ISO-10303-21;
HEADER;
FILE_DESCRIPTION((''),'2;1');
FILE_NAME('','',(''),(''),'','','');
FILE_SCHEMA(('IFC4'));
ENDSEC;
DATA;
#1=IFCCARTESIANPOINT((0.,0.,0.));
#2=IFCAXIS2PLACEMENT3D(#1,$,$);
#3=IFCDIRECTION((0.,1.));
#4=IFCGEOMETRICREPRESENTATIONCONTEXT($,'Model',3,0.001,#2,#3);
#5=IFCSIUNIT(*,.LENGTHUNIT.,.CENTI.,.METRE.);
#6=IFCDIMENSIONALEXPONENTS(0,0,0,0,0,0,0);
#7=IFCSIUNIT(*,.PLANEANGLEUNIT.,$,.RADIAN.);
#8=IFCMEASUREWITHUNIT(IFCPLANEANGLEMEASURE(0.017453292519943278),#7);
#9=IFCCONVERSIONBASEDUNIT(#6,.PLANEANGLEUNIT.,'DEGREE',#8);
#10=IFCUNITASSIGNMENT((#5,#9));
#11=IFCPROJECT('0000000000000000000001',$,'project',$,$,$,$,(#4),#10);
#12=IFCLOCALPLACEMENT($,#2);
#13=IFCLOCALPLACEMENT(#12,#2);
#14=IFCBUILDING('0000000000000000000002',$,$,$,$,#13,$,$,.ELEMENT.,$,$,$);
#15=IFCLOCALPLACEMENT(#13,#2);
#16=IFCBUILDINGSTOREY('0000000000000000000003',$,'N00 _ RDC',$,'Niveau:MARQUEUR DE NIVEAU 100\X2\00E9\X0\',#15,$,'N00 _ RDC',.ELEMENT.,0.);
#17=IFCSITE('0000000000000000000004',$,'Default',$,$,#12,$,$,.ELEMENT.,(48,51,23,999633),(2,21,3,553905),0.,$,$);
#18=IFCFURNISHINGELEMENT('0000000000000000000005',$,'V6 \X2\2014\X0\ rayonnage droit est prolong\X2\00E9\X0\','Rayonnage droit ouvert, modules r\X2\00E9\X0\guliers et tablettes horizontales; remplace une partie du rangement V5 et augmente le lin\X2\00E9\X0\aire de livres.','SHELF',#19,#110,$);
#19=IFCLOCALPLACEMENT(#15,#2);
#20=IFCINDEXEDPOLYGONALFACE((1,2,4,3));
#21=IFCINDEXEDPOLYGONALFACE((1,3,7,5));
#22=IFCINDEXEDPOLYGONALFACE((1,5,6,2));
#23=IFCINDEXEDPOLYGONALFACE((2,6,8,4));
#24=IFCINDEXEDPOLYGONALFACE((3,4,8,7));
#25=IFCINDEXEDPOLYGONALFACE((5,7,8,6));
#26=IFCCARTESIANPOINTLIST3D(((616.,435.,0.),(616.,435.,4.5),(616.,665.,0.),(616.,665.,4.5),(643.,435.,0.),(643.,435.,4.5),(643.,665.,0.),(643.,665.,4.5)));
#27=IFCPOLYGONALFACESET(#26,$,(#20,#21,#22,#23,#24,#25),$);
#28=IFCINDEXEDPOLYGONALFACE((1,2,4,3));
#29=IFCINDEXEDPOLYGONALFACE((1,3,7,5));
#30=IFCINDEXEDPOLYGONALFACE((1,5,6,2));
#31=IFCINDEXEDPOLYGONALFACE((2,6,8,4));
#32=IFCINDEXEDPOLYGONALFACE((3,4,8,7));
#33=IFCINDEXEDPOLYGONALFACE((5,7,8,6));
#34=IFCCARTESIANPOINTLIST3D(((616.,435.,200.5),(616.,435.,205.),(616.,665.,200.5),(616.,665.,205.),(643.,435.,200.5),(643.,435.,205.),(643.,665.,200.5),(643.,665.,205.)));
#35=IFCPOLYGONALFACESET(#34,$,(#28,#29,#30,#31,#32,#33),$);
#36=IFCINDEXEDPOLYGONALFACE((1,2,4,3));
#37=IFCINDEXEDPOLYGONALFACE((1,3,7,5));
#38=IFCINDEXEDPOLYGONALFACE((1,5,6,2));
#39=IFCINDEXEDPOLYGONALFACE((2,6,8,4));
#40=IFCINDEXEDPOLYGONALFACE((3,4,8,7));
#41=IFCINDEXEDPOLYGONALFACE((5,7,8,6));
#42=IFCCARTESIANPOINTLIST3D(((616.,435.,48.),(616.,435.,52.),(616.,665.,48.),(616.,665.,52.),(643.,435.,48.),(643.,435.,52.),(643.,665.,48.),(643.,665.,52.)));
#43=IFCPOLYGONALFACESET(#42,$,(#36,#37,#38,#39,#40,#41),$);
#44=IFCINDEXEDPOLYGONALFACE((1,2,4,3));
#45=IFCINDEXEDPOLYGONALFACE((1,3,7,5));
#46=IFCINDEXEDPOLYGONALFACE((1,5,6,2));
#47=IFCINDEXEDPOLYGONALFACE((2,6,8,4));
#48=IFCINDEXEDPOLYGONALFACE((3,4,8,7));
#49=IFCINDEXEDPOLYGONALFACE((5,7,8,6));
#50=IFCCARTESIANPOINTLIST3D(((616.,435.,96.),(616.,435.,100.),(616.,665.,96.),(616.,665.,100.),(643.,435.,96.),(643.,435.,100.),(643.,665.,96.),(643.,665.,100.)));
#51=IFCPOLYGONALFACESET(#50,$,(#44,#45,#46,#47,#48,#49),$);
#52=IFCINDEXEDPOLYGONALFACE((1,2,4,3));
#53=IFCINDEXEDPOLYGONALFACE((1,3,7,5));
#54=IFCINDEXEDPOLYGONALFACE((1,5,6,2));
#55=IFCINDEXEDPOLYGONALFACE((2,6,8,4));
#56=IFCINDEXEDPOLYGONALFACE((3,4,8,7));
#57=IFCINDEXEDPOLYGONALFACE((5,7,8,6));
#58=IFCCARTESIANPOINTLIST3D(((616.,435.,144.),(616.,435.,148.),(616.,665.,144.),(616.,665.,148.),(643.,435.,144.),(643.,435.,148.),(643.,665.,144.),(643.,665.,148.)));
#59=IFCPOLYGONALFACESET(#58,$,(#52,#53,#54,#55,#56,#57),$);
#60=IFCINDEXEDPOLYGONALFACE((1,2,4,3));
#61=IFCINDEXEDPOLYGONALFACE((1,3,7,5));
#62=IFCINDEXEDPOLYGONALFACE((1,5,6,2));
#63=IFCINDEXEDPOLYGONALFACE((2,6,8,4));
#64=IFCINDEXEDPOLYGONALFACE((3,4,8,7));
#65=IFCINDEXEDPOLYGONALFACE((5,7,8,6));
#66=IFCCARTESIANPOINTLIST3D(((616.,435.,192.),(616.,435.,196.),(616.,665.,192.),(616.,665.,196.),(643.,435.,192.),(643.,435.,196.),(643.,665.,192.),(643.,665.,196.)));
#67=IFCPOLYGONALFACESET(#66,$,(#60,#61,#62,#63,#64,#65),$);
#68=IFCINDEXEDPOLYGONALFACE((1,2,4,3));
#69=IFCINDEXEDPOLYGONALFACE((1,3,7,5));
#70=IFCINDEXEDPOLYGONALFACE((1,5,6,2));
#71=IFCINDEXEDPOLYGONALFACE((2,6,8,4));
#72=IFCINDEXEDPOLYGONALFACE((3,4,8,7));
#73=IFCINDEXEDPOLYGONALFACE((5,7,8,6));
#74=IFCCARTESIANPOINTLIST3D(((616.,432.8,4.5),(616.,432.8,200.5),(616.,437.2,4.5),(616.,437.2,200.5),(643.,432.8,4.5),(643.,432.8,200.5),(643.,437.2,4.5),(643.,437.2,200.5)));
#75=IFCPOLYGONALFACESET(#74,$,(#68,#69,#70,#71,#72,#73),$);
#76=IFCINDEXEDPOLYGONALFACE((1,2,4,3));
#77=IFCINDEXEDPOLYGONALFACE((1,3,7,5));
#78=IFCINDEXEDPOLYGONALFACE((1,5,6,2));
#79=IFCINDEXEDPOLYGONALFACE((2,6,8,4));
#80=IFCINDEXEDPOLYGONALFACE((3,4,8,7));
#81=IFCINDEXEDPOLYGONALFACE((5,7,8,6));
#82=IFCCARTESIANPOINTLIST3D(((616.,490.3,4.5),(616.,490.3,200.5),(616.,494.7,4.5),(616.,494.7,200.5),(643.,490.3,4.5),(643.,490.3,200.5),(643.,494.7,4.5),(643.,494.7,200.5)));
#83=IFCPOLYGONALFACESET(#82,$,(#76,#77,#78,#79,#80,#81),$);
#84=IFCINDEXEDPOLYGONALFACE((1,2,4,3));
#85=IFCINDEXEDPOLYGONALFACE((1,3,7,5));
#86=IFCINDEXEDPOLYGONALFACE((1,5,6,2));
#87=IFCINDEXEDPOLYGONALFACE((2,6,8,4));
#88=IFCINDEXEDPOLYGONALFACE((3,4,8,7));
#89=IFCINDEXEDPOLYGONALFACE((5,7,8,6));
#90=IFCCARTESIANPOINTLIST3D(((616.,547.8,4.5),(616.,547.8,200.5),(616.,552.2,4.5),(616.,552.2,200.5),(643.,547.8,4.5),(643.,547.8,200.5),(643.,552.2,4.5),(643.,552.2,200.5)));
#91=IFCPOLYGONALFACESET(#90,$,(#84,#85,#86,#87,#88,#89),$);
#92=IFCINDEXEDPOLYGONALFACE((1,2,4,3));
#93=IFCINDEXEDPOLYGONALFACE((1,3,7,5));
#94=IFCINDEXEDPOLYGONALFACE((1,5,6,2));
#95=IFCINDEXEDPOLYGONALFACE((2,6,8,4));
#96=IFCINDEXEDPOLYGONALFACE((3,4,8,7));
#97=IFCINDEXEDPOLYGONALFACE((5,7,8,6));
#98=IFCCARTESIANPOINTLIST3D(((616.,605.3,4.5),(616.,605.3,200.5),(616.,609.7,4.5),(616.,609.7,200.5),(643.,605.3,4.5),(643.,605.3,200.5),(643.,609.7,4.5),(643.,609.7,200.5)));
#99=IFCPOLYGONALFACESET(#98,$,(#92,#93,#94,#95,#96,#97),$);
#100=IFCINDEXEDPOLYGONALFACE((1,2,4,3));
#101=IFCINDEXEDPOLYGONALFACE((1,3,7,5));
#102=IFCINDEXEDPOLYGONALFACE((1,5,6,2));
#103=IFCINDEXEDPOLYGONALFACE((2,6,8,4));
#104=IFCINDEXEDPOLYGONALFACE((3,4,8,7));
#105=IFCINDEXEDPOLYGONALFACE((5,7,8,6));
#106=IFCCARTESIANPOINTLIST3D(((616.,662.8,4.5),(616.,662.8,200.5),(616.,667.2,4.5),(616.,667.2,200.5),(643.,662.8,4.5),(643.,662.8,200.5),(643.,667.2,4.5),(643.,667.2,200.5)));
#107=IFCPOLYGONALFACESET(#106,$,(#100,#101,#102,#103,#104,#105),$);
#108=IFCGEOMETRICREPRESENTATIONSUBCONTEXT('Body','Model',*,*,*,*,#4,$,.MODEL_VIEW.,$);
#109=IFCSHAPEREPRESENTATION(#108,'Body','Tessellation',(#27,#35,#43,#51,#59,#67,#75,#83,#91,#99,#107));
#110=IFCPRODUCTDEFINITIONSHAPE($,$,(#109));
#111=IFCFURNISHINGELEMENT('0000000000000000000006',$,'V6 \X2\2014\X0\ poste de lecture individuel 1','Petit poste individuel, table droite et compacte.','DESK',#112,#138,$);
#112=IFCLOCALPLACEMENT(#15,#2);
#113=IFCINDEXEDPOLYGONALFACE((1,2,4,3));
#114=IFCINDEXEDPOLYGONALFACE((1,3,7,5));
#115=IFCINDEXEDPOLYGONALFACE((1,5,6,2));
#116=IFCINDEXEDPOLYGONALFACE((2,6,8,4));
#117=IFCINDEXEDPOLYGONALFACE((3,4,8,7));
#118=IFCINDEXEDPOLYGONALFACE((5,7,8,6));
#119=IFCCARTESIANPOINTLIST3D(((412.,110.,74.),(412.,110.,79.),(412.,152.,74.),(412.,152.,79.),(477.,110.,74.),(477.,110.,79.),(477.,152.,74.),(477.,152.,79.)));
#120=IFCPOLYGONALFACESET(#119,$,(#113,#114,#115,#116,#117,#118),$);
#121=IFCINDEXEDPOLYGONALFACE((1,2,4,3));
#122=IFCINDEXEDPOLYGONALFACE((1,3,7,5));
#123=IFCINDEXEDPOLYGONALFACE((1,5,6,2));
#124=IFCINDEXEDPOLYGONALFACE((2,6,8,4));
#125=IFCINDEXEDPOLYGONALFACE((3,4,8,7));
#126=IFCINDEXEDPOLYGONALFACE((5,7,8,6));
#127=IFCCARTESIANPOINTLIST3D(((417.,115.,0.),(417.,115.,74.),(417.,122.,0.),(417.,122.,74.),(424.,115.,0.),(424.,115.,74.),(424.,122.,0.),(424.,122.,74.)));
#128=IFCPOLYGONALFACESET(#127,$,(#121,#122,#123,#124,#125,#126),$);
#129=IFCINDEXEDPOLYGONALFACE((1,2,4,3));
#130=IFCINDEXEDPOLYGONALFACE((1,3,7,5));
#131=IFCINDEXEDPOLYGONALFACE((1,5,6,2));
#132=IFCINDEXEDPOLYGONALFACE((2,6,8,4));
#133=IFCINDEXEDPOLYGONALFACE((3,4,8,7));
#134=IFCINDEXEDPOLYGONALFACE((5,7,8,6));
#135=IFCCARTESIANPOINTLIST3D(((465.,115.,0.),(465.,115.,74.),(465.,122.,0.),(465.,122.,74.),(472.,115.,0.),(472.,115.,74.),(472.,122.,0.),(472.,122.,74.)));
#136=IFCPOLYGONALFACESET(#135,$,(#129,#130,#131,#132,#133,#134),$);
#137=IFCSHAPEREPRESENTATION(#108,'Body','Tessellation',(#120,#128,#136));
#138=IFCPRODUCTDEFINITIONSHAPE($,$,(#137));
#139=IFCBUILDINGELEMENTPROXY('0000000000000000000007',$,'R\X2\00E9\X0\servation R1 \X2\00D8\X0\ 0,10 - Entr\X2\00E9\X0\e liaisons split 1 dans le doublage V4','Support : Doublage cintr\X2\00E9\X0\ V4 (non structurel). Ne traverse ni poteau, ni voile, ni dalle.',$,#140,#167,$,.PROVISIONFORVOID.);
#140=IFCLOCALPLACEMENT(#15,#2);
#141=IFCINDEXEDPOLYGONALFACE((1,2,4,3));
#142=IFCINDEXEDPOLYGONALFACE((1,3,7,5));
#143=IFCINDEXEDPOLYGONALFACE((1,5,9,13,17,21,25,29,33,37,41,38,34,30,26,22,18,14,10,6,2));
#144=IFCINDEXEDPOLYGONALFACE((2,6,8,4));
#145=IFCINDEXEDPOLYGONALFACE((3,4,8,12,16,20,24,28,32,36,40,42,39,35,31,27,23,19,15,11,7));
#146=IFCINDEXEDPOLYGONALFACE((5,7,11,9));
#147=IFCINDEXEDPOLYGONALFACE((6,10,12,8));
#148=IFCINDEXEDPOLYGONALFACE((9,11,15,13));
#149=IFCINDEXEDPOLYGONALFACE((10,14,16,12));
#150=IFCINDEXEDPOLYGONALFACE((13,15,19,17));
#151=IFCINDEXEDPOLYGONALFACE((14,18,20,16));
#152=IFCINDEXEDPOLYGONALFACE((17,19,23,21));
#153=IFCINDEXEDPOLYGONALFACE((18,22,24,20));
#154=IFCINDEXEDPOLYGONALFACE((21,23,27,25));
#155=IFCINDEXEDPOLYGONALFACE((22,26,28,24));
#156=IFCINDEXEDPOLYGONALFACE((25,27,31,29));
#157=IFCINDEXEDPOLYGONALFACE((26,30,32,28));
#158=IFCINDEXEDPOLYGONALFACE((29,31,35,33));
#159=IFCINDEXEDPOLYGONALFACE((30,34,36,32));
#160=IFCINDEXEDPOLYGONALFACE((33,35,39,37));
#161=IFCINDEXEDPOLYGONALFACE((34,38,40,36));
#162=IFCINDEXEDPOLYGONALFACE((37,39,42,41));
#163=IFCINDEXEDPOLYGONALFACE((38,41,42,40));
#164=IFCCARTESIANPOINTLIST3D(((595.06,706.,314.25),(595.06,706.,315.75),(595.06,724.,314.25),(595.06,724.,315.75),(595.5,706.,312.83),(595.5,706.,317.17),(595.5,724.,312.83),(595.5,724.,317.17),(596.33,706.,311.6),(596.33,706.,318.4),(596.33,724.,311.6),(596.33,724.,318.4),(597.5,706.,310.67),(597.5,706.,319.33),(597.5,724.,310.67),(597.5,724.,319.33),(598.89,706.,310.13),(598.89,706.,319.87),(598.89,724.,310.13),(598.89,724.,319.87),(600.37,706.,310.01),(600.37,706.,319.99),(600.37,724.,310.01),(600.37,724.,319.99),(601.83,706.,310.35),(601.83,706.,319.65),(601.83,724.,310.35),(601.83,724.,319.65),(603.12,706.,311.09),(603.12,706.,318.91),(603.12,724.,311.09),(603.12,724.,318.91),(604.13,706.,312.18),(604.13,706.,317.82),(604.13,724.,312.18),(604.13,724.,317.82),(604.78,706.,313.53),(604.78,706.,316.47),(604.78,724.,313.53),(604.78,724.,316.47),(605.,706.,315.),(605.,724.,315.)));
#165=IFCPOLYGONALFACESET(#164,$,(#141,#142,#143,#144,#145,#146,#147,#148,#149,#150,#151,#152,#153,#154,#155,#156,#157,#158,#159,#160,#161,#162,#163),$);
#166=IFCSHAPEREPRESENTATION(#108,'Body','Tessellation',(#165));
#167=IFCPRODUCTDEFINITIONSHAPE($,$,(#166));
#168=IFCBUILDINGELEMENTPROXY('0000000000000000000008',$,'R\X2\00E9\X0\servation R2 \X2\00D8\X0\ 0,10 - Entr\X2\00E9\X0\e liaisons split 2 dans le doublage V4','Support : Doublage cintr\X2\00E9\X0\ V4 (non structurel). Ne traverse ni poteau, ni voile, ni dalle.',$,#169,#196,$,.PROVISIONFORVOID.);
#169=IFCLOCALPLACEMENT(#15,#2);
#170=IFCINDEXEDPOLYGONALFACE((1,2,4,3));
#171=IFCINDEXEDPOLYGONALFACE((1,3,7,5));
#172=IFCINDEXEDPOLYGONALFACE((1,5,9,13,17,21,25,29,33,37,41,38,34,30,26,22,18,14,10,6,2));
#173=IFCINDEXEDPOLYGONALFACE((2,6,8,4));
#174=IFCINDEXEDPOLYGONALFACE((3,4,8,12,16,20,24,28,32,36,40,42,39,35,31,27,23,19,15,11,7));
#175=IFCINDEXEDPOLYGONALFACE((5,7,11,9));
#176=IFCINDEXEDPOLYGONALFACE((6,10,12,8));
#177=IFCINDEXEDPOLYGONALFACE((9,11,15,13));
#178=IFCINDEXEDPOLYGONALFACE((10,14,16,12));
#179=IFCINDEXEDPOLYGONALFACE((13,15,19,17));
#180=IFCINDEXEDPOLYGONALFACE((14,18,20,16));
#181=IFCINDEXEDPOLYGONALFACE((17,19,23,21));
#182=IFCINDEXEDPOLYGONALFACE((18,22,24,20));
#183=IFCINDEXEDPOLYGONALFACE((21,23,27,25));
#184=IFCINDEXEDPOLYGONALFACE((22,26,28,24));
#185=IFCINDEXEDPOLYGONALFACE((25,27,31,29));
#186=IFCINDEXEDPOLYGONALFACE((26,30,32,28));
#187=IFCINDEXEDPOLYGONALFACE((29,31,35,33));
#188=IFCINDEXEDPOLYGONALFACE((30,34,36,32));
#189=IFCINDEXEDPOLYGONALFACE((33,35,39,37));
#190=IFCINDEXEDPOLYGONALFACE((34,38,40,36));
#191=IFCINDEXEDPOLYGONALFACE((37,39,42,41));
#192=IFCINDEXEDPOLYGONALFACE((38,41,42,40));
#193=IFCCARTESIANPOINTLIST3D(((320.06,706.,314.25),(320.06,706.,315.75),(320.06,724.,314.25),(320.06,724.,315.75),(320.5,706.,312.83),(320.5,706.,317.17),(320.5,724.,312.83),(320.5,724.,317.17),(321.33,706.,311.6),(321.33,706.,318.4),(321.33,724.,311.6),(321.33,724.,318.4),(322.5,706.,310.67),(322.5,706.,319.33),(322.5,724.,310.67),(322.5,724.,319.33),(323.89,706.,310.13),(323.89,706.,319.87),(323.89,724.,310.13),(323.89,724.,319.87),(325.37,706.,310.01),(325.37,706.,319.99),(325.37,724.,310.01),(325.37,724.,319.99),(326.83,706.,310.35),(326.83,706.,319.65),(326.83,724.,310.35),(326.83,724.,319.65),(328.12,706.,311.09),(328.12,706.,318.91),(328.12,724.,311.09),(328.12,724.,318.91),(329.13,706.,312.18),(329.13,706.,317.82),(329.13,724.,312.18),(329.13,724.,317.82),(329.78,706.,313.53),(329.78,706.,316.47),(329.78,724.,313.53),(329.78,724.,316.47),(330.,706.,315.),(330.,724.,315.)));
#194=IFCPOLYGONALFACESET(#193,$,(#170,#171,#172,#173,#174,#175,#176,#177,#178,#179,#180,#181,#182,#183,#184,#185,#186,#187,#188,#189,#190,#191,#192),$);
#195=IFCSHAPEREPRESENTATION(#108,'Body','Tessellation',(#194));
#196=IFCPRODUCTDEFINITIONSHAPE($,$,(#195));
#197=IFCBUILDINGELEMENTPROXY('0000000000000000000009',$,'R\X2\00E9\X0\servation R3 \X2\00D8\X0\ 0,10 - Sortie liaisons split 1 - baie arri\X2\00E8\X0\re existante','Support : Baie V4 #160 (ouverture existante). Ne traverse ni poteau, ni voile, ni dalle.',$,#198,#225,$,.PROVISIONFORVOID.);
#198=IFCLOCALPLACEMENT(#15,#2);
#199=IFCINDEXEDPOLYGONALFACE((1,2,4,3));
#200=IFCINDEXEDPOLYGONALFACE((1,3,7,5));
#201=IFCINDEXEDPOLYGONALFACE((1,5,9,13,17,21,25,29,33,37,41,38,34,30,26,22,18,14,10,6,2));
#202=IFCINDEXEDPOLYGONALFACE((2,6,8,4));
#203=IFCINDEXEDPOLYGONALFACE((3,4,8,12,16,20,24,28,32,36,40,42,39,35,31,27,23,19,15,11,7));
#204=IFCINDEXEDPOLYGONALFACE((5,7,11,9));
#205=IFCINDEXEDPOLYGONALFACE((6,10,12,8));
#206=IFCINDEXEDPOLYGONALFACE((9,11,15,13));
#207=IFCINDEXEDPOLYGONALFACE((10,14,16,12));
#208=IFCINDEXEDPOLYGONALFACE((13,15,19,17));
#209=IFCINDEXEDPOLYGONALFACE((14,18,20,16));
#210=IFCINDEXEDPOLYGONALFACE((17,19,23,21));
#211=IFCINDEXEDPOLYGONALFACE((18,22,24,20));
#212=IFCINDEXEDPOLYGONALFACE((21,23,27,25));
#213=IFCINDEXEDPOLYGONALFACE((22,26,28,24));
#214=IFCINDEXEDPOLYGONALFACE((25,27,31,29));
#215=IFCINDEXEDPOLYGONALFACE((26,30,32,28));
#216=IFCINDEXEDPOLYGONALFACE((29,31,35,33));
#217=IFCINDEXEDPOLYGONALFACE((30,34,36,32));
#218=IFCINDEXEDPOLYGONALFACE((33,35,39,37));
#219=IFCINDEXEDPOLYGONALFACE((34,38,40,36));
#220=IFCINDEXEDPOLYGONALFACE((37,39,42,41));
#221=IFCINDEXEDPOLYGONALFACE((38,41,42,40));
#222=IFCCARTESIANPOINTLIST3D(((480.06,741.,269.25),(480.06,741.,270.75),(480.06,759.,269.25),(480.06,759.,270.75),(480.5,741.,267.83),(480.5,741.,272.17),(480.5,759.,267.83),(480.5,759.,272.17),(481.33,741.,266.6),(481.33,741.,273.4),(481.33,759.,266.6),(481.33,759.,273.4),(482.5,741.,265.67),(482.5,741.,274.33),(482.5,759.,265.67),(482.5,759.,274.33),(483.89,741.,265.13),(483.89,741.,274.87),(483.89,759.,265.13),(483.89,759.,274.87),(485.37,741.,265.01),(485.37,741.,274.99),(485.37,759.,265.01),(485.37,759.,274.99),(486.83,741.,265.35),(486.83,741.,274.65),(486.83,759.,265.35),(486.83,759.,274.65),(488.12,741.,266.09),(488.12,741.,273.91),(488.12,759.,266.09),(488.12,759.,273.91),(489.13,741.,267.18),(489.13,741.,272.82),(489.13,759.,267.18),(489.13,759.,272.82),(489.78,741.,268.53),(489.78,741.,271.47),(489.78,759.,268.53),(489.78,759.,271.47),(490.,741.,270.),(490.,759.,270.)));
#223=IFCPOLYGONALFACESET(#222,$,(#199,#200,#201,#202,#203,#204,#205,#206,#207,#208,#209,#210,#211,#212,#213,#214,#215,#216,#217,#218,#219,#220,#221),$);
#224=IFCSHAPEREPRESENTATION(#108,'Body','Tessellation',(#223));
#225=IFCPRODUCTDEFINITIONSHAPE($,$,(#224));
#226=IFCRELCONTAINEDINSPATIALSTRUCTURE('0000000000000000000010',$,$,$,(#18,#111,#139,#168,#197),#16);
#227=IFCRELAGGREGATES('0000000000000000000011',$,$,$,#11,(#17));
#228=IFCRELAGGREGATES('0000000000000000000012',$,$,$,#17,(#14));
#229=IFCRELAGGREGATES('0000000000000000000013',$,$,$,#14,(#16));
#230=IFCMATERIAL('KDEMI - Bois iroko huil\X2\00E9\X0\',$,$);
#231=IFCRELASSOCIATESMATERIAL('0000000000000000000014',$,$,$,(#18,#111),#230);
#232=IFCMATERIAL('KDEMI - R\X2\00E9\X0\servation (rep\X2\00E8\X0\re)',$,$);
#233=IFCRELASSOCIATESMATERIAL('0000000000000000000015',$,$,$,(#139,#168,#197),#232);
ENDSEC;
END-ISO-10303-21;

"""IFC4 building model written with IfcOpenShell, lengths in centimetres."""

from ifc_helpers import new_model, entity, si_unit, converted_unit, direction, frame, frame_2d, origin, origin_with_axes, origin_2d, place, context, subcontext, project, spatial, rectangle, circle, extrude, material, element, save


model = new_model("IFC4")

# Units and contexts
model_context = context("Model", 3, precision=0.001, world=origin(), true_north=direction((0.0, 1.0)))
body_context = subcontext(model_context, "Body", "Model", "MODEL_VIEW")
ifc_project = project(units=[si_unit("LENGTHUNIT", "METRE", prefix="CENTI"), converted_unit("PLANEANGLEUNIT", "DEGREE", entity("IfcPlaneAngleMeasure", 0.017453292519943278), si_unit("PLANEANGLEUNIT", "RADIAN"), dimensions=[0, 0, 0, 0, 0, 0, 0])], contexts=[model_context])

# Site, building, storey
site_placement = place(None, origin())
site = spatial("IfcSite", under=ifc_project, at=site_placement, Name="Default", CompositionType="ELEMENT", RefLatitude=(48, 51, 23, 999633), RefLongitude=(2, 21, 3, 553905), RefElevation=0.0)
building_placement = place(site_placement, origin())
building = spatial("IfcBuilding", under=site, at=building_placement, CompositionType="ELEMENT")
storey_placement = place(building_placement, origin())
storey = spatial("IfcBuildingStorey", under=building, at=storey_placement, Name="N00 _ RDC", ObjectType="Niveau:MARQUEUR DE NIVEAU 100é", LongName="N00 _ RDC", CompositionType="ELEMENT", Elevation=0.0)

# Furnishing elements
ifc_material_1 = material(Name="KDEMI - Bois iroko huilé")
furnishing_1_placement = place(storey_placement, origin_with_axes())
element("IfcFurnishingElement", 1, at=furnishing_1_placement, inside=storey, material=ifc_material_1, Name="V6 — rayonnage droit est prolongé", Description="Rayonnage droit ouvert, modules réguliers et tablettes horizontales; remplace une partie du rangement V5 et augmente le linéaire de livres.", ObjectType="SHELF", context=body_context, shape_type="SweptSolid", body=[
    extrude(rectangle(XDim=27.0, YDim=230.0, at=frame_2d((629.5, 550.0))), origin(), (0.0, 0.0, 1.0), 4.5),
    extrude(rectangle(XDim=27.0, YDim=230.0, at=frame_2d((629.5, 550.0))), frame((0.0, 0.0, 200.5)), (0.0, 0.0, 1.0), 4.5),
    extrude(rectangle(XDim=27.0, YDim=230.0, at=frame_2d((629.5, 550.0))), frame((0.0, 0.0, 48.0)), (0.0, 0.0, 1.0), 4.0),
    extrude(rectangle(XDim=27.0, YDim=230.0, at=frame_2d((629.5, 550.0))), frame((0.0, 0.0, 96.0)), (0.0, 0.0, 1.0), 4.0),
    extrude(rectangle(XDim=27.0, YDim=230.0, at=frame_2d((629.5, 550.0))), frame((0.0, 0.0, 144.0)), (0.0, 0.0, 1.0), 4.0),
    extrude(rectangle(XDim=27.0, YDim=230.0, at=frame_2d((629.5, 550.0))), frame((0.0, 0.0, 192.0)), (0.0, 0.0, 1.0), 4.0),
    extrude(rectangle(XDim=27.0, YDim=4.4, at=frame_2d((629.5, 435.0))), frame((0.0, 0.0, 4.5)), (0.0, 0.0, 1.0), 196.0),
    extrude(rectangle(XDim=27.0, YDim=4.4, at=frame_2d((629.5, 492.5))), frame((0.0, 0.0, 4.5)), (0.0, 0.0, 1.0), 196.0),
    extrude(rectangle(XDim=27.0, YDim=4.4, at=frame_2d((629.5, 550.0))), frame((0.0, 0.0, 4.5)), (0.0, 0.0, 1.0), 196.0),
    extrude(rectangle(XDim=27.0, YDim=4.4, at=frame_2d((629.5, 607.5))), frame((0.0, 0.0, 4.5)), (0.0, 0.0, 1.0), 196.0),
    extrude(rectangle(XDim=27.0, YDim=4.4, at=frame_2d((629.5, 665.0))), frame((0.0, 0.0, 4.5)), (0.0, 0.0, 1.0), 196.0),
])
furnishing_2_placement = place(storey_placement, origin_with_axes())
element("IfcFurnishingElement", 2, at=furnishing_2_placement, inside=storey, material=ifc_material_1, Name="V6 — poste de lecture individuel 1", Description="Petit poste individuel, table droite et compacte.", ObjectType="DESK", context=body_context, shape_type="SweptSolid", body=[
    extrude(rectangle(XDim=65.0, YDim=42.0, at=frame_2d((444.5, 131.0))), frame((0.0, 0.0, 74.0)), (0.0, 0.0, 1.0), 5.0),
    extrude(rectangle(XDim=7.0, YDim=7.0, at=frame_2d((420.5, 118.5))), origin(), (0.0, 0.0, 1.0), 74.0),
    extrude(rectangle(XDim=7.0, YDim=7.0, at=frame_2d((468.5, 118.5))), origin(), (0.0, 0.0, 1.0), 74.0),
])

# Building element proxies
ifc_material_2 = material(Name="KDEMI - Réservation (repère)")
proxy_1_placement = place(storey_placement, origin_with_axes())
element("IfcBuildingElementProxy", 3, at=proxy_1_placement, inside=storey, material=ifc_material_2, Name="Réservation R1 Ø 0,10 - Entrée liaisons split 1 dans le doublage V4", Description="Support : Doublage cintré V4 (non structurel). Ne traverse ni poteau, ni voile, ni dalle.", PredefinedType="PROVISIONFORVOID", context=body_context, shape_type="SweptSolid", body=[
    extrude(circle(Radius=5.0, at=origin_2d()), frame((600.0, 706.0, 315.0), z_axis=(0.0, 1.0, 0.0), x_axis=(1.0, 0.0, 0.0)), (0.0, 0.0, 1.0), 18.0),
])
proxy_2_placement = place(storey_placement, origin_with_axes())
element("IfcBuildingElementProxy", 4, at=proxy_2_placement, inside=storey, material=ifc_material_2, Name="Réservation R2 Ø 0,10 - Entrée liaisons split 2 dans le doublage V4", Description="Support : Doublage cintré V4 (non structurel). Ne traverse ni poteau, ni voile, ni dalle.", PredefinedType="PROVISIONFORVOID", context=body_context, shape_type="SweptSolid", body=[
    extrude(circle(Radius=5.0, at=origin_2d()), frame((325.0, 706.0, 315.0), z_axis=(0.0, 1.0, 0.0), x_axis=(1.0, 0.0, 0.0)), (0.0, 0.0, 1.0), 18.0),
])
proxy_3_placement = place(storey_placement, origin_with_axes())
element("IfcBuildingElementProxy", 5, at=proxy_3_placement, inside=storey, material=ifc_material_2, Name="Réservation R3 Ø 0,10 - Sortie liaisons split 1 - baie arrière existante", Description="Support : Baie V4 #160 (ouverture existante). Ne traverse ni poteau, ni voile, ni dalle.", PredefinedType="PROVISIONFORVOID", context=body_context, shape_type="SweptSolid", body=[
    extrude(circle(Radius=5.0, at=origin_2d()), frame((485.0, 741.0, 270.0), z_axis=(0.0, 1.0, 0.0), x_axis=(1.0, 0.0, 0.0)), (0.0, 0.0, 1.0), 18.0),
])

save(model, "model.ifc")
